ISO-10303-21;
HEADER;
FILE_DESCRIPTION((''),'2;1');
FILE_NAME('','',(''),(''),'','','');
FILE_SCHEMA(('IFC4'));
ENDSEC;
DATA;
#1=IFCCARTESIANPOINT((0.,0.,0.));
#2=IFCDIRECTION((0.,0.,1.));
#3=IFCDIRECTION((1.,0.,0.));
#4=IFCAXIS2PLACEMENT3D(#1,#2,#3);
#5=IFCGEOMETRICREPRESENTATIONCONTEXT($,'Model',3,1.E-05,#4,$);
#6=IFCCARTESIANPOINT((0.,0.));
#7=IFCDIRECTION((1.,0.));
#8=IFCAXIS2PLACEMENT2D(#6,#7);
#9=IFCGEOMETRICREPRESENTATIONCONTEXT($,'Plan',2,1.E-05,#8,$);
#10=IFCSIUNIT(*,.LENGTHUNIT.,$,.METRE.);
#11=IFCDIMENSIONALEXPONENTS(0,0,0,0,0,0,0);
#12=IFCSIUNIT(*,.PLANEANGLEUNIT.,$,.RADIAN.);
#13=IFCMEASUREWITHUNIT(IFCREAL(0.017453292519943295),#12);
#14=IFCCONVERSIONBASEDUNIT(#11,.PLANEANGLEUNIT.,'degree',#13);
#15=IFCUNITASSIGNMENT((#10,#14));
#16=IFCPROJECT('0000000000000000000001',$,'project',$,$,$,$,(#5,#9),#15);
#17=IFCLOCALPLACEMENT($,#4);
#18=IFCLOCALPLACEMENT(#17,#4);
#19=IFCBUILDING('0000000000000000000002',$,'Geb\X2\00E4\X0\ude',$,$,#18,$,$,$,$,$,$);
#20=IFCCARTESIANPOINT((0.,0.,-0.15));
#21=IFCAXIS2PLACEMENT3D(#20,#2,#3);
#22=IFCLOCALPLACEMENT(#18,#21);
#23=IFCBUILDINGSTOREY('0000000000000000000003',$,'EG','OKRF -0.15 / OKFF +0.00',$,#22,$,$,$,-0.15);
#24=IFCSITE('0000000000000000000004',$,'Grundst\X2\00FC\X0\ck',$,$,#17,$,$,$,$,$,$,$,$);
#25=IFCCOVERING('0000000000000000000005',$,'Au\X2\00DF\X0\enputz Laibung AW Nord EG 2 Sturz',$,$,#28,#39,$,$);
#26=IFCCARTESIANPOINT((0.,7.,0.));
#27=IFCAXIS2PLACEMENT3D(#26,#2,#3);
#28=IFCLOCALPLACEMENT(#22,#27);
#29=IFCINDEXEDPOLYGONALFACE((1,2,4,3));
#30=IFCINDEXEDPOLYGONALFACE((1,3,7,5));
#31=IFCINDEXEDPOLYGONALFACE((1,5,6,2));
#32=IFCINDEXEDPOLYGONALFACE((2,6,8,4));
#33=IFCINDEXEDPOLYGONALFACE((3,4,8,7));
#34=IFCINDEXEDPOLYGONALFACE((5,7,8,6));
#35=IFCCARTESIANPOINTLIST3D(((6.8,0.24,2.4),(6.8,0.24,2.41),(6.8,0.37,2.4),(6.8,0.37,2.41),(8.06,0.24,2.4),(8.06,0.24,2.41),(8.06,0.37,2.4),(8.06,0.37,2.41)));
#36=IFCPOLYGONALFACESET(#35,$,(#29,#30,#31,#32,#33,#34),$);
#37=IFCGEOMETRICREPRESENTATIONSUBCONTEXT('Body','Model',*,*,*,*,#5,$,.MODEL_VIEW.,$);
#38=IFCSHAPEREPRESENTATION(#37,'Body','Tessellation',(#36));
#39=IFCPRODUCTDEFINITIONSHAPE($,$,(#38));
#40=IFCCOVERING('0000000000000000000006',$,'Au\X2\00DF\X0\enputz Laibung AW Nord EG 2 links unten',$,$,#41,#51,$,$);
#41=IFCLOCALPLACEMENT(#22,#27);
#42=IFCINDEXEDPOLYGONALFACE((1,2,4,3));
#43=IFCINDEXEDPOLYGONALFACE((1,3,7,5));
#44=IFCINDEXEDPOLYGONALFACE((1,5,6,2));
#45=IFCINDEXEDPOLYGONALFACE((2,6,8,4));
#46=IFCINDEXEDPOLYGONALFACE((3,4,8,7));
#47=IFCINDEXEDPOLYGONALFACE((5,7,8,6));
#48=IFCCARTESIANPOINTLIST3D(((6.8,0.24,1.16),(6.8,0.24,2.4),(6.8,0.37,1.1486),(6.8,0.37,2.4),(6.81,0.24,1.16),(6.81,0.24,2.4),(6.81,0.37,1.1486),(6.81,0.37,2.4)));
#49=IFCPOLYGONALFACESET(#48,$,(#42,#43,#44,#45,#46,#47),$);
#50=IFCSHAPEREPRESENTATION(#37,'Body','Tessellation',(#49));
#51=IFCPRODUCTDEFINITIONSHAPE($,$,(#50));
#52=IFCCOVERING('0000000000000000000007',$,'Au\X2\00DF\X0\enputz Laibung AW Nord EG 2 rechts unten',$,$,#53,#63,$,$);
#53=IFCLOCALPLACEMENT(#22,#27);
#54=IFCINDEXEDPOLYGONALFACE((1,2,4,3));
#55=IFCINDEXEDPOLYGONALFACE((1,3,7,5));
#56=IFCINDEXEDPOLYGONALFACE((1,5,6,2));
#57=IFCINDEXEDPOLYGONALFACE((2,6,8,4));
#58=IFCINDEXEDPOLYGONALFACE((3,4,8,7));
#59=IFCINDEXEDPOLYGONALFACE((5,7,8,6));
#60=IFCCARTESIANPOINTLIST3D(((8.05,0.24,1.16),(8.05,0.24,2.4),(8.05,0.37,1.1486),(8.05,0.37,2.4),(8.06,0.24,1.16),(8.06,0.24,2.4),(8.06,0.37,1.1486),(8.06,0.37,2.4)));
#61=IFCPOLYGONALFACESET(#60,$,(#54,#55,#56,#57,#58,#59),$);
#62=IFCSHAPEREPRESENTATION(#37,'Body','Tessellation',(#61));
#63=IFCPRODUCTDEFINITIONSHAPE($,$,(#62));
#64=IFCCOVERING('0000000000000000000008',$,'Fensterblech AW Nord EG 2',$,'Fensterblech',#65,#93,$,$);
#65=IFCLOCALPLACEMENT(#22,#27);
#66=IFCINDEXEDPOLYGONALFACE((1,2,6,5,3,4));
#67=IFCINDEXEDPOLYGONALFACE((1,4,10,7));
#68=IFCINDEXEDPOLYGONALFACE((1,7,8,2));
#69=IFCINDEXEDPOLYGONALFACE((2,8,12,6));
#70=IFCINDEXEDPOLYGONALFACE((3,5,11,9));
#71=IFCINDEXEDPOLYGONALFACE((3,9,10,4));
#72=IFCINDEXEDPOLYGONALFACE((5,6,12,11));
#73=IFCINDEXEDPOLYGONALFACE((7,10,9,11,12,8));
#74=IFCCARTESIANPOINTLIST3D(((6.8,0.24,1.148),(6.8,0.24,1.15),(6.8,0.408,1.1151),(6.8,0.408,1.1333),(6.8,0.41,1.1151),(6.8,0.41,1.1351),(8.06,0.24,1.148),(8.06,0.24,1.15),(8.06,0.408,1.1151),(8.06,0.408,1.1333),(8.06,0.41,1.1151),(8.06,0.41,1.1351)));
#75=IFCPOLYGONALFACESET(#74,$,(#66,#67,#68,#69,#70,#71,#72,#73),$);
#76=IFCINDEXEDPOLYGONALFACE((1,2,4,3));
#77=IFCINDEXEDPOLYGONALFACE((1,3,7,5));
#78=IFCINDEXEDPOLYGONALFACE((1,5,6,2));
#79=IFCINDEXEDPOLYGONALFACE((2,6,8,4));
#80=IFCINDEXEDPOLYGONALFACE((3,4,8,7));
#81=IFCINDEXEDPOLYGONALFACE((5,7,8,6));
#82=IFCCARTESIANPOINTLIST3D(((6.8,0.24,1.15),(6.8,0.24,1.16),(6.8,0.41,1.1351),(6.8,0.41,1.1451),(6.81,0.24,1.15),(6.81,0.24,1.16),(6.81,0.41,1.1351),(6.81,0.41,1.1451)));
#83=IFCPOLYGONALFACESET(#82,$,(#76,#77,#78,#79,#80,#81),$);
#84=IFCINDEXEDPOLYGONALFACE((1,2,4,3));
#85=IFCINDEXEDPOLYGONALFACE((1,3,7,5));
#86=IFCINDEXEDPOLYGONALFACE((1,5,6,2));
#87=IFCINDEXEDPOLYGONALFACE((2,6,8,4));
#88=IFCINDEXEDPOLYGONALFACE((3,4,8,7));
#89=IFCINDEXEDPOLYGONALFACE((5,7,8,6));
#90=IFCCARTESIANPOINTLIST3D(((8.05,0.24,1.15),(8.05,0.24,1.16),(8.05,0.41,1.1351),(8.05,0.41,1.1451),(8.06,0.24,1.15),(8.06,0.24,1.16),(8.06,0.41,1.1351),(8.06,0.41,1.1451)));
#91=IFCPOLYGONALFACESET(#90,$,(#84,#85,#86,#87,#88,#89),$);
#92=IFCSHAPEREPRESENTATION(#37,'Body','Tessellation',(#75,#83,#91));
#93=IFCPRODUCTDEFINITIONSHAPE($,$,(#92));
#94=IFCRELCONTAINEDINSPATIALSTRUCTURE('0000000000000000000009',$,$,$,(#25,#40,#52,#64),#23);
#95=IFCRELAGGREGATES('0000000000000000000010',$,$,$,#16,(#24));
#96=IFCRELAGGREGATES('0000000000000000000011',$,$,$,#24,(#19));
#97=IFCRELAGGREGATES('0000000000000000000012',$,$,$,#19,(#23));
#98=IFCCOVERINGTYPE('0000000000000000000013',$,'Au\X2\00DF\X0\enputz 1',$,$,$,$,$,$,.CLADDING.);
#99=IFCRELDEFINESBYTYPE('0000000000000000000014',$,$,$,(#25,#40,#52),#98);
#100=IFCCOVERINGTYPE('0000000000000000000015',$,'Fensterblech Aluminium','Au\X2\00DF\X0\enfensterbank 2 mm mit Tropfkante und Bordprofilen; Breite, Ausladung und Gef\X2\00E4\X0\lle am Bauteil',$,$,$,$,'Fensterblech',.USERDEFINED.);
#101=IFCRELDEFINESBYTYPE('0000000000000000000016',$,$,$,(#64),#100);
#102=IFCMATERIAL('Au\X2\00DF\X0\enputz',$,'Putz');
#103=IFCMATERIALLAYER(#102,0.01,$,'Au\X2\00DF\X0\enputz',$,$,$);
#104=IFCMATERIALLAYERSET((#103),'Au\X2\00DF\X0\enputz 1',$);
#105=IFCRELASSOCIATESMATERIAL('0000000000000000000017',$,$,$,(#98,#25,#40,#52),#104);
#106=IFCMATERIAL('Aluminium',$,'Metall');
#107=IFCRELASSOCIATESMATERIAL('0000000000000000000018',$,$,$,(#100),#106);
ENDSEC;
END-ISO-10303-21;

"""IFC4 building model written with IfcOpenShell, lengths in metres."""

from ifc_helpers import new_model, entity, si_unit, converted_unit, frame, origin_with_axes, origin_2d_with_axis, place, context, subcontext, project, spatial, polyline, outline, extrude, material, layer, layer_set, layer_usage, type_object, element, save


model = new_model("IFC4")

# Units and contexts
model_context = context("Model", 3, precision=1e-05, world=origin_with_axes())
plan_context = context("Plan", 2, precision=1e-05, world=origin_2d_with_axis())
body_context = subcontext(model_context, "Body", "Model", "MODEL_VIEW")
ifc_project = project(units=[si_unit("LENGTHUNIT", "METRE"), converted_unit("PLANEANGLEUNIT", "degree", entity("IfcReal", 0.017453292519943295), si_unit("PLANEANGLEUNIT", "RADIAN"), dimensions=[0, 0, 0, 0, 0, 0, 0])], contexts=[model_context, plan_context])

# Site, building, storey
site_placement = place(None, origin_with_axes())
site = spatial("IfcSite", under=ifc_project, at=site_placement, Name="Grundstück")
building_placement = place(site_placement, origin_with_axes())
building = spatial("IfcBuilding", under=site, at=building_placement, Name="Gebäude")
storey_placement = place(building_placement, frame((0.0, 0.0, -0.15), z_axis=(0.0, 0.0, 1.0), x_axis=(1.0, 0.0, 0.0)))
storey = spatial("IfcBuildingStorey", under=building, at=storey_placement, Name="EG", Description="OKRF -0.15 / OKFF +0.00", Elevation=-0.15)

# Coverings
ifc_material_1 = material(Name="Außenputz", Category="Putz")
ifc_layer_1 = layer(ifc_material_1, 0.01, Name="Außenputz")
ifc_layer_set_1 = layer_set([ifc_layer_1], Name="Außenputz 1")
ifc_layer_usage_1 = layer_usage(ifc_layer_set_1, "AXIS3", "POSITIVE", 2.4)
covering_type_1 = type_object("IfcCoveringType", Name="Außenputz 1", PredefinedType="CLADDING", material=ifc_layer_set_1)
covering_1_placement = place(storey_placement, frame((0.0, 7.0, 0.0), z_axis=(0.0, 0.0, 1.0), x_axis=(1.0, 0.0, 0.0)))
element("IfcCovering", 1, at=covering_1_placement, inside=storey, type_object=covering_type_1, material=ifc_layer_usage_1, Name="Außenputz Laibung AW Nord EG 2 Sturz", context=body_context, shape_type="SweptSolid", body=[
    extrude(outline(polyline([(0.24, 2.4), (0.37, 2.4), (0.37, 2.41), (0.24, 2.41), (0.24, 2.4)])), frame((6.8, 0.0, 0.0), z_axis=(1.0, 0.0, 0.0), x_axis=(0.0, 1.0, 0.0)), (0.0, 0.0, 1.0), 1.26),
])
ifc_layer_usage_2 = layer_usage(ifc_layer_set_1, "AXIS1", "POSITIVE", 6.8)
covering_2_placement = place(storey_placement, frame((0.0, 7.0, 0.0), z_axis=(0.0, 0.0, 1.0), x_axis=(1.0, 0.0, 0.0)))
element("IfcCovering", 2, at=covering_2_placement, inside=storey, type_object=covering_type_1, material=ifc_layer_usage_2, Name="Außenputz Laibung AW Nord EG 2 links unten", context=body_context, shape_type="SweptSolid", body=[
    extrude(outline(polyline([(0.24, 1.16), (0.37, 1.1486), (0.37, 2.4), (0.24, 2.4), (0.24, 1.16)])), frame((6.8, 0.0, 0.0), z_axis=(1.0, 0.0, 0.0), x_axis=(0.0, 1.0, 0.0)), (0.0, 0.0, 1.0), 0.01),
])
ifc_layer_usage_3 = layer_usage(ifc_layer_set_1, "AXIS1", "POSITIVE", 8.05)
covering_3_placement = place(storey_placement, frame((0.0, 7.0, 0.0), z_axis=(0.0, 0.0, 1.0), x_axis=(1.0, 0.0, 0.0)))
element("IfcCovering", 3, at=covering_3_placement, inside=storey, type_object=covering_type_1, material=ifc_layer_usage_3, Name="Außenputz Laibung AW Nord EG 2 rechts unten", context=body_context, shape_type="SweptSolid", body=[
    extrude(outline(polyline([(0.24, 1.16), (0.37, 1.1486), (0.37, 2.4), (0.24, 2.4), (0.24, 1.16)])), frame((8.05, 0.0, 0.0), z_axis=(1.0, 0.0, 0.0), x_axis=(0.0, 1.0, 0.0)), (0.0, 0.0, 1.0), 0.01),
])

# Covering
ifc_material_2 = material(Name="Aluminium", Category="Metall")
covering_type_2 = type_object("IfcCoveringType", Name="Fensterblech Aluminium", Description="Außenfensterbank 2 mm mit Tropfkante und Bordprofilen; Breite, Ausladung und Gefälle am Bauteil", ElementType="Fensterblech", PredefinedType="USERDEFINED", material=ifc_material_2)
covering_4_placement = place(storey_placement, frame((0.0, 7.0, 0.0), z_axis=(0.0, 0.0, 1.0), x_axis=(1.0, 0.0, 0.0)))
element("IfcCovering", 4, at=covering_4_placement, inside=storey, type_object=covering_type_2, Name="Fensterblech AW Nord EG 2", ObjectType="Fensterblech", context=body_context, shape_type="SweptSolid", body=[
    extrude(outline(polyline([(0.24, 1.148), (0.408, 1.1333), (0.408, 1.1151), (0.41, 1.1151), (0.41, 1.1351), (0.24, 1.15), (0.24, 1.148)])), frame((6.8, 0.0, 0.0), z_axis=(1.0, 0.0, 0.0), x_axis=(0.0, 1.0, 0.0)), (0.0, 0.0, 1.0), 1.26),
    extrude(outline(polyline([(0.24, 1.15), (0.41, 1.1351), (0.41, 1.1451), (0.24, 1.16), (0.24, 1.15)])), frame((6.8, 0.0, 0.0), z_axis=(1.0, 0.0, 0.0), x_axis=(0.0, 1.0, 0.0)), (0.0, 0.0, 1.0), 0.01),
    extrude(outline(polyline([(0.24, 1.15), (0.41, 1.1351), (0.41, 1.1451), (0.24, 1.16), (0.24, 1.15)])), frame((8.05, 0.0, 0.0), z_axis=(1.0, 0.0, 0.0), x_axis=(0.0, 1.0, 0.0)), (0.0, 0.0, 1.0), 0.01),
])

save(model, "model.ifc")
